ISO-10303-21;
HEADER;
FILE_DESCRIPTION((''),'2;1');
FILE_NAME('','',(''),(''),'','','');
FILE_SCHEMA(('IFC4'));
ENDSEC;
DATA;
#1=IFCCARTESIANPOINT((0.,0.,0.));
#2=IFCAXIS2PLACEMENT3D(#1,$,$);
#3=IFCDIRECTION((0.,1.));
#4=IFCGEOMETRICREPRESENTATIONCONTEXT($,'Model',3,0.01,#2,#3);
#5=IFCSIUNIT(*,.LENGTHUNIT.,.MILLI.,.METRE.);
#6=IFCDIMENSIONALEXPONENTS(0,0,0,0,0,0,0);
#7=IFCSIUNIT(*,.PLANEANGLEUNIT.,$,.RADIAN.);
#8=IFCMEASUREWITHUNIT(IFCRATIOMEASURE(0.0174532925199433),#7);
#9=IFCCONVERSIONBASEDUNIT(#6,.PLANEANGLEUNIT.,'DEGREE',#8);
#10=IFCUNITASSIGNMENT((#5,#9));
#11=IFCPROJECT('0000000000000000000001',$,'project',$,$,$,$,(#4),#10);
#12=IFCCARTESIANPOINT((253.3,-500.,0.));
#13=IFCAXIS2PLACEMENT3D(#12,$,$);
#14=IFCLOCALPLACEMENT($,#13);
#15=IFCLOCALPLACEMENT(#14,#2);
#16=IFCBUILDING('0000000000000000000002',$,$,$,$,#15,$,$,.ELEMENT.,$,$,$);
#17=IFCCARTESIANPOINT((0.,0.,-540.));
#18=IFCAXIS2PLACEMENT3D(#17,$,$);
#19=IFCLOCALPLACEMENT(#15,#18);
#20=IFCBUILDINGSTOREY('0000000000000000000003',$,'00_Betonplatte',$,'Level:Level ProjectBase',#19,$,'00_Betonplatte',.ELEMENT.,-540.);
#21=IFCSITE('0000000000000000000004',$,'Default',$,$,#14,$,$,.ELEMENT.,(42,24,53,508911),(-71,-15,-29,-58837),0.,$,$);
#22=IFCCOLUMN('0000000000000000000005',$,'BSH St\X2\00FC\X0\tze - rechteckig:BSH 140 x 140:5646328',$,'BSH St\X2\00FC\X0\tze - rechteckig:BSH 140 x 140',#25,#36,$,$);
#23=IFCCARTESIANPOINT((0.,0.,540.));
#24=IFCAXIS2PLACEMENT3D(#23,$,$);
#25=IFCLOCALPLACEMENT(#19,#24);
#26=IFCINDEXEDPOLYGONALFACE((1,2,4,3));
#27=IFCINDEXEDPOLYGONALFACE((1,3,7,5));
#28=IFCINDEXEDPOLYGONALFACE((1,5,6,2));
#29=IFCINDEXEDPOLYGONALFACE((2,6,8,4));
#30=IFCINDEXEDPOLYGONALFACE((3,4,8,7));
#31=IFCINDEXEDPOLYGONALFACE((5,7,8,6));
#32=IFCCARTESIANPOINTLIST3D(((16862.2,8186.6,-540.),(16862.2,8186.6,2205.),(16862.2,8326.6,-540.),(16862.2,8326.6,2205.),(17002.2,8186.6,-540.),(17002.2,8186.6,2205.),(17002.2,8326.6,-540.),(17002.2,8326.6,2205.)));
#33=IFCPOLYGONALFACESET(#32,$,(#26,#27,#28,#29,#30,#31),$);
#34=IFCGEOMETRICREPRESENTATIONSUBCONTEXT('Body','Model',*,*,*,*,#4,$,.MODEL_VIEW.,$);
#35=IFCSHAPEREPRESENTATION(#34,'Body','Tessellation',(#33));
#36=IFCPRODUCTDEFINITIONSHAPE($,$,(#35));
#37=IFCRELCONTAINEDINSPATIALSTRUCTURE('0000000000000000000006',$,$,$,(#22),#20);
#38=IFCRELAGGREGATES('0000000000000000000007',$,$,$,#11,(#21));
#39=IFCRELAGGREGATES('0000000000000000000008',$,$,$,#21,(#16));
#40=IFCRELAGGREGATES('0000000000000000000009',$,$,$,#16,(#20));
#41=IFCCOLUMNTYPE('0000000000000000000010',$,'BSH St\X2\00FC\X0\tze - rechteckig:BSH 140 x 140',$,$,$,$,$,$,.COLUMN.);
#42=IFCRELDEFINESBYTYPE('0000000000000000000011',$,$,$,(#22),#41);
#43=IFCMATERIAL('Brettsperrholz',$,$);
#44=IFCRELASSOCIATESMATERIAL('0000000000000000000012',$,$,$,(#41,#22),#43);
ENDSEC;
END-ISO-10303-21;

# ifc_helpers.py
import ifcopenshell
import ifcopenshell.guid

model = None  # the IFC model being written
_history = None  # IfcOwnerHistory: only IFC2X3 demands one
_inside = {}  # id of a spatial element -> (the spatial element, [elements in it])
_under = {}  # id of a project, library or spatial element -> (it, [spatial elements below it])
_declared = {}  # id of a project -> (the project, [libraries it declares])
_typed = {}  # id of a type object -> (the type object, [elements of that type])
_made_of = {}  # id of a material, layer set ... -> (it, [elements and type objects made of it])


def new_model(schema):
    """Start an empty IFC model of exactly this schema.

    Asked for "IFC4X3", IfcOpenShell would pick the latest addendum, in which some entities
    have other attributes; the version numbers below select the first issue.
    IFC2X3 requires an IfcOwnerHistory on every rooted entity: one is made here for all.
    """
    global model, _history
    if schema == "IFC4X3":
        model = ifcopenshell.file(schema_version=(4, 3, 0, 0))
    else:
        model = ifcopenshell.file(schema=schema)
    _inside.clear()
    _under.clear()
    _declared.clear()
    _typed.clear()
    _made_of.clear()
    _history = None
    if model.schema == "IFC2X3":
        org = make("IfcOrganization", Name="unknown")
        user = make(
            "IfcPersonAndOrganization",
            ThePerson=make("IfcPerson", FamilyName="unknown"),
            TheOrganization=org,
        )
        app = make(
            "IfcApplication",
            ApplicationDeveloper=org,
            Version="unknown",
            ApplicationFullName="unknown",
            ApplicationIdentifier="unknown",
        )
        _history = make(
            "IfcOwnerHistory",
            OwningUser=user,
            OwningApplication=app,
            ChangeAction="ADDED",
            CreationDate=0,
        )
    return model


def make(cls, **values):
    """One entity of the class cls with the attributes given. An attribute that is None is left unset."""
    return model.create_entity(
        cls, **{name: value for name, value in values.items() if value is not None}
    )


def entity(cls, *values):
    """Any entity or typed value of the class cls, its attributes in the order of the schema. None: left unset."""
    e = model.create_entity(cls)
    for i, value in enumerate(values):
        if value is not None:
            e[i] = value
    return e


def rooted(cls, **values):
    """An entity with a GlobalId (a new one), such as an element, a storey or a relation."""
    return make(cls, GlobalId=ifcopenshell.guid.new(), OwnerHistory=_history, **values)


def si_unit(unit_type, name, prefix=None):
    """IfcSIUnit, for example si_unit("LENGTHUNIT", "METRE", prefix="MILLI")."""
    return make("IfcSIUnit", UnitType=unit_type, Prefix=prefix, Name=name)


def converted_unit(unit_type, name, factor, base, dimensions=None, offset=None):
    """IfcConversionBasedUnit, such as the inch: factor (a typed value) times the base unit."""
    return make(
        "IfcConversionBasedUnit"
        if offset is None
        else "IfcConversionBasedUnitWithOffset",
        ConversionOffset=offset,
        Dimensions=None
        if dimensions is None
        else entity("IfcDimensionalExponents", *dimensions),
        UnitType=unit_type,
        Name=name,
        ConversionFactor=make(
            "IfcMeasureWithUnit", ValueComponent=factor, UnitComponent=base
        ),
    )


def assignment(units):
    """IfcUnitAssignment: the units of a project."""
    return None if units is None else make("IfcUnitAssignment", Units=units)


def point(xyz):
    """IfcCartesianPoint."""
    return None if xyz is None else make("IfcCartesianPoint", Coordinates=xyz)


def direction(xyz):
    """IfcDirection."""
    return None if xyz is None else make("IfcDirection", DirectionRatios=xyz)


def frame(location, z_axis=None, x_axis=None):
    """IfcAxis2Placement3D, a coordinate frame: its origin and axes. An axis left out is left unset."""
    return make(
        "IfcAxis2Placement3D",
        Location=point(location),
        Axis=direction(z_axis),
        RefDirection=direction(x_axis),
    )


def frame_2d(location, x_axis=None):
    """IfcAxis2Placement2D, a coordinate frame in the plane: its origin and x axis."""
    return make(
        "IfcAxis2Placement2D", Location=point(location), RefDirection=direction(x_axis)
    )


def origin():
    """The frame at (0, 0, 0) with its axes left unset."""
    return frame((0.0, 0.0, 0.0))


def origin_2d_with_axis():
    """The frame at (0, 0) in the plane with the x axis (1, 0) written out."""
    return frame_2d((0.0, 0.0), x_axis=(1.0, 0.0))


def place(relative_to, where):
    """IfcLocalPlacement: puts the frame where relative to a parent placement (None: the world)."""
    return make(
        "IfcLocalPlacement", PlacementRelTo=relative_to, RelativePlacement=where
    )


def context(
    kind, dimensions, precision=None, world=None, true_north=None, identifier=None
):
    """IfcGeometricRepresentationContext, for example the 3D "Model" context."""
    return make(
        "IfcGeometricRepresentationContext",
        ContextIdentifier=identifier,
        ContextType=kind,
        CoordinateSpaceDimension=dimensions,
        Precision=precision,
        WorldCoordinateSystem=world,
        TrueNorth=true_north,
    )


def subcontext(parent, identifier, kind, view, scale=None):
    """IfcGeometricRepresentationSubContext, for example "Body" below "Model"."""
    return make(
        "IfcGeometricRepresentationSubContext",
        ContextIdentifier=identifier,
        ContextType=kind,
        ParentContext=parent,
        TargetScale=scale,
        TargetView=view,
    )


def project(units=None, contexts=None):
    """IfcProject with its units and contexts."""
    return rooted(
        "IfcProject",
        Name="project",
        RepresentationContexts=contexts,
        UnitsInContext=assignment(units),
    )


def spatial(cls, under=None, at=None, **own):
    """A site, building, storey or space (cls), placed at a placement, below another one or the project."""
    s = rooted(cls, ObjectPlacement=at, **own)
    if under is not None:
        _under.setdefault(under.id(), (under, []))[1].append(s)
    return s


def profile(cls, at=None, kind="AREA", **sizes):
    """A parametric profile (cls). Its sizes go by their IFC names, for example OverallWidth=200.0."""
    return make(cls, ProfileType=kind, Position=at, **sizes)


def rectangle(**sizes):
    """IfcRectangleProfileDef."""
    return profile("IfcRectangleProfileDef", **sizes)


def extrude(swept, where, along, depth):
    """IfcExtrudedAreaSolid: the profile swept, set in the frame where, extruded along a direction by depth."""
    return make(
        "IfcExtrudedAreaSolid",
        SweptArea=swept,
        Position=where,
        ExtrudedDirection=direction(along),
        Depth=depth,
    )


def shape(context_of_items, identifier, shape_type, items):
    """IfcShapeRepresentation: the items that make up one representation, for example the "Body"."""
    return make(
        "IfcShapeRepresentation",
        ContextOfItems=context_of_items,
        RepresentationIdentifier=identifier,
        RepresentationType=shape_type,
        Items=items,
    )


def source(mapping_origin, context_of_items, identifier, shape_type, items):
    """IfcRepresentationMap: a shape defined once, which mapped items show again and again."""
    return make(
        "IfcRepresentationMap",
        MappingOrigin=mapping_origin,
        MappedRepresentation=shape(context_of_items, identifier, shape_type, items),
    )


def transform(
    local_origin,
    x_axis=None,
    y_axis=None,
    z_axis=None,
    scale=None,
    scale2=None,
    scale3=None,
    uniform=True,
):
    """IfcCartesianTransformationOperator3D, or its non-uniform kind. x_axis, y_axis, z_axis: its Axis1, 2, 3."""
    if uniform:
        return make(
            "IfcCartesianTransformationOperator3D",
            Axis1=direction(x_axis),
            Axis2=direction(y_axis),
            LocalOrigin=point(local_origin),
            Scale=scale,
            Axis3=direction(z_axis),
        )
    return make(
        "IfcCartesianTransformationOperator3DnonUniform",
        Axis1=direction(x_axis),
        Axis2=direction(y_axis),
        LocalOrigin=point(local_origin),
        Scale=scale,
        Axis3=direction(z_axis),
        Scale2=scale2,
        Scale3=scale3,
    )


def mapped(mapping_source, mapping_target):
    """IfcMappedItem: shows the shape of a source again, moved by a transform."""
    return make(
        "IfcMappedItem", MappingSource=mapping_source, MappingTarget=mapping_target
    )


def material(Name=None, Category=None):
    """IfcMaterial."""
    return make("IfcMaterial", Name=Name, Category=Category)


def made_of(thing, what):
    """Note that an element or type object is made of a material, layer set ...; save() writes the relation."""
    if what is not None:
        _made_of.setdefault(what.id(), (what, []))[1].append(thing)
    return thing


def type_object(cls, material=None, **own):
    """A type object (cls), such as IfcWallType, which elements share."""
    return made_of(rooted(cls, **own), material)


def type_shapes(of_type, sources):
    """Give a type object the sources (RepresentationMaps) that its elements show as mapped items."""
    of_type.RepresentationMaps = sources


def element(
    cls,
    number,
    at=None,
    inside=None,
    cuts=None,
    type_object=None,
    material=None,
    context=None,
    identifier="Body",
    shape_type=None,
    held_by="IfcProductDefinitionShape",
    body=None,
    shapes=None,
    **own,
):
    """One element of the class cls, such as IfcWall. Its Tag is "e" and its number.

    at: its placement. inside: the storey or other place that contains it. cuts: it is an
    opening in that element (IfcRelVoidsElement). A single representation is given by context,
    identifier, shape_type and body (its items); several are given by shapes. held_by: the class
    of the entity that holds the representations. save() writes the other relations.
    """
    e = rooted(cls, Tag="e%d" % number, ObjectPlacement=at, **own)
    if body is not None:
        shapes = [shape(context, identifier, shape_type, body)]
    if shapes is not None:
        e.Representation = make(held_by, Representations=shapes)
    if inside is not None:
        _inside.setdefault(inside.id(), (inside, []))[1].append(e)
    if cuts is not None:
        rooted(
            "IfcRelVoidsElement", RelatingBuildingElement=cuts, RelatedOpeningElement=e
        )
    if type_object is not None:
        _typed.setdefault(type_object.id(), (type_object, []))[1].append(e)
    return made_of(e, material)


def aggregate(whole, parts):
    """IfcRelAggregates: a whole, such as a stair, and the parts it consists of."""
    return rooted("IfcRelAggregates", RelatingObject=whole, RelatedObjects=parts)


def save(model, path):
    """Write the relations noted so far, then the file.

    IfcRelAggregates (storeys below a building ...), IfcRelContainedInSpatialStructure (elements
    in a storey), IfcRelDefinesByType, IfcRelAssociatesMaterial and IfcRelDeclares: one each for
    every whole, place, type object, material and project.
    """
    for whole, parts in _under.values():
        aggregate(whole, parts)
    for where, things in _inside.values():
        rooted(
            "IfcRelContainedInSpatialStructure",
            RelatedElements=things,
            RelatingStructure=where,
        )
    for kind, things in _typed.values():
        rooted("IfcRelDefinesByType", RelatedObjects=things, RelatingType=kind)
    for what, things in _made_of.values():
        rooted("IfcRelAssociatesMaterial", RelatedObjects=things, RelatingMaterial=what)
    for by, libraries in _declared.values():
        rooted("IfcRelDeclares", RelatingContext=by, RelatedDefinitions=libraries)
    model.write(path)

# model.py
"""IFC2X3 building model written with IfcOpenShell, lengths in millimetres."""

from ifc_helpers import new_model, entity, si_unit, converted_unit, direction, frame, origin, origin_2d_with_axis, place, context, subcontext, project, spatial, rectangle, extrude, source, transform, mapped, material, type_object, type_shapes, element, save


model = new_model("IFC2X3")

# Units and contexts
model_context = context("Model", 3, precision=0.01, world=origin(), true_north=direction((0.0, 1.0)))
body_context = subcontext(model_context, "Body", "Model", "MODEL_VIEW")
ifc_project = project(units=[si_unit("LENGTHUNIT", "METRE", prefix="MILLI"), converted_unit("PLANEANGLEUNIT", "DEGREE", entity("IfcRatioMeasure", 0.0174532925199433), si_unit("PLANEANGLEUNIT", "RADIAN"), dimensions=[0, 0, 0, 0, 0, 0, 0])], contexts=[model_context])

# Site, building, storey
site_placement = place(None, frame((253.3, -500.0, 0.0)))
site = spatial("IfcSite", under=ifc_project, at=site_placement, Name="Default", CompositionType="ELEMENT", RefLatitude=(42, 24, 53, 508911), RefLongitude=(-71, -15, -29, -58837), RefElevation=0.0)
building_placement = place(site_placement, origin())
building = spatial("IfcBuilding", under=site, at=building_placement, CompositionType="ELEMENT")
storey_placement = place(building_placement, frame((0.0, 0.0, -540.0)))
storey = spatial("IfcBuildingStorey", under=building, at=storey_placement, Name="00_Betonplatte", ObjectType="Level:Level ProjectBase", LongName="00_Betonplatte", CompositionType="ELEMENT", Elevation=-540.0)

# Column
ifc_material_1 = material(Name="Brettsperrholz")
column_type = type_object("IfcColumnType", Name="BSH Stütze - rechteckig:BSH 140 x 140", PredefinedType="COLUMN", material=ifc_material_1)
shared_shape = source(origin(), body_context, "Body", "SweptSolid", [
    extrude(rectangle(XDim=140.0, YDim=140.0, at=origin_2d_with_axis()), frame((16932.2, 8256.6, -540.0), z_axis=(0.0, 0.0, 1.0), x_axis=(0.0, -1.0, 0.0)), (0.0, 0.0, 1.0), 2745.0),
])
type_shapes(column_type, [shared_shape])
column_placement = place(storey_placement, frame((0.0, 0.0, 540.0)))
element("IfcColumn", 1, at=column_placement, inside=storey, type_object=column_type, material=ifc_material_1, Name="BSH Stütze - rechteckig:BSH 140 x 140:5646328", ObjectType="BSH Stütze - rechteckig:BSH 140 x 140", context=body_context, shape_type="MappedRepresentation", body=[
    mapped(shared_shape, transform((0.0, 0.0, 0.0), scale=1.0)),
])

save(model, "model.ifc")
